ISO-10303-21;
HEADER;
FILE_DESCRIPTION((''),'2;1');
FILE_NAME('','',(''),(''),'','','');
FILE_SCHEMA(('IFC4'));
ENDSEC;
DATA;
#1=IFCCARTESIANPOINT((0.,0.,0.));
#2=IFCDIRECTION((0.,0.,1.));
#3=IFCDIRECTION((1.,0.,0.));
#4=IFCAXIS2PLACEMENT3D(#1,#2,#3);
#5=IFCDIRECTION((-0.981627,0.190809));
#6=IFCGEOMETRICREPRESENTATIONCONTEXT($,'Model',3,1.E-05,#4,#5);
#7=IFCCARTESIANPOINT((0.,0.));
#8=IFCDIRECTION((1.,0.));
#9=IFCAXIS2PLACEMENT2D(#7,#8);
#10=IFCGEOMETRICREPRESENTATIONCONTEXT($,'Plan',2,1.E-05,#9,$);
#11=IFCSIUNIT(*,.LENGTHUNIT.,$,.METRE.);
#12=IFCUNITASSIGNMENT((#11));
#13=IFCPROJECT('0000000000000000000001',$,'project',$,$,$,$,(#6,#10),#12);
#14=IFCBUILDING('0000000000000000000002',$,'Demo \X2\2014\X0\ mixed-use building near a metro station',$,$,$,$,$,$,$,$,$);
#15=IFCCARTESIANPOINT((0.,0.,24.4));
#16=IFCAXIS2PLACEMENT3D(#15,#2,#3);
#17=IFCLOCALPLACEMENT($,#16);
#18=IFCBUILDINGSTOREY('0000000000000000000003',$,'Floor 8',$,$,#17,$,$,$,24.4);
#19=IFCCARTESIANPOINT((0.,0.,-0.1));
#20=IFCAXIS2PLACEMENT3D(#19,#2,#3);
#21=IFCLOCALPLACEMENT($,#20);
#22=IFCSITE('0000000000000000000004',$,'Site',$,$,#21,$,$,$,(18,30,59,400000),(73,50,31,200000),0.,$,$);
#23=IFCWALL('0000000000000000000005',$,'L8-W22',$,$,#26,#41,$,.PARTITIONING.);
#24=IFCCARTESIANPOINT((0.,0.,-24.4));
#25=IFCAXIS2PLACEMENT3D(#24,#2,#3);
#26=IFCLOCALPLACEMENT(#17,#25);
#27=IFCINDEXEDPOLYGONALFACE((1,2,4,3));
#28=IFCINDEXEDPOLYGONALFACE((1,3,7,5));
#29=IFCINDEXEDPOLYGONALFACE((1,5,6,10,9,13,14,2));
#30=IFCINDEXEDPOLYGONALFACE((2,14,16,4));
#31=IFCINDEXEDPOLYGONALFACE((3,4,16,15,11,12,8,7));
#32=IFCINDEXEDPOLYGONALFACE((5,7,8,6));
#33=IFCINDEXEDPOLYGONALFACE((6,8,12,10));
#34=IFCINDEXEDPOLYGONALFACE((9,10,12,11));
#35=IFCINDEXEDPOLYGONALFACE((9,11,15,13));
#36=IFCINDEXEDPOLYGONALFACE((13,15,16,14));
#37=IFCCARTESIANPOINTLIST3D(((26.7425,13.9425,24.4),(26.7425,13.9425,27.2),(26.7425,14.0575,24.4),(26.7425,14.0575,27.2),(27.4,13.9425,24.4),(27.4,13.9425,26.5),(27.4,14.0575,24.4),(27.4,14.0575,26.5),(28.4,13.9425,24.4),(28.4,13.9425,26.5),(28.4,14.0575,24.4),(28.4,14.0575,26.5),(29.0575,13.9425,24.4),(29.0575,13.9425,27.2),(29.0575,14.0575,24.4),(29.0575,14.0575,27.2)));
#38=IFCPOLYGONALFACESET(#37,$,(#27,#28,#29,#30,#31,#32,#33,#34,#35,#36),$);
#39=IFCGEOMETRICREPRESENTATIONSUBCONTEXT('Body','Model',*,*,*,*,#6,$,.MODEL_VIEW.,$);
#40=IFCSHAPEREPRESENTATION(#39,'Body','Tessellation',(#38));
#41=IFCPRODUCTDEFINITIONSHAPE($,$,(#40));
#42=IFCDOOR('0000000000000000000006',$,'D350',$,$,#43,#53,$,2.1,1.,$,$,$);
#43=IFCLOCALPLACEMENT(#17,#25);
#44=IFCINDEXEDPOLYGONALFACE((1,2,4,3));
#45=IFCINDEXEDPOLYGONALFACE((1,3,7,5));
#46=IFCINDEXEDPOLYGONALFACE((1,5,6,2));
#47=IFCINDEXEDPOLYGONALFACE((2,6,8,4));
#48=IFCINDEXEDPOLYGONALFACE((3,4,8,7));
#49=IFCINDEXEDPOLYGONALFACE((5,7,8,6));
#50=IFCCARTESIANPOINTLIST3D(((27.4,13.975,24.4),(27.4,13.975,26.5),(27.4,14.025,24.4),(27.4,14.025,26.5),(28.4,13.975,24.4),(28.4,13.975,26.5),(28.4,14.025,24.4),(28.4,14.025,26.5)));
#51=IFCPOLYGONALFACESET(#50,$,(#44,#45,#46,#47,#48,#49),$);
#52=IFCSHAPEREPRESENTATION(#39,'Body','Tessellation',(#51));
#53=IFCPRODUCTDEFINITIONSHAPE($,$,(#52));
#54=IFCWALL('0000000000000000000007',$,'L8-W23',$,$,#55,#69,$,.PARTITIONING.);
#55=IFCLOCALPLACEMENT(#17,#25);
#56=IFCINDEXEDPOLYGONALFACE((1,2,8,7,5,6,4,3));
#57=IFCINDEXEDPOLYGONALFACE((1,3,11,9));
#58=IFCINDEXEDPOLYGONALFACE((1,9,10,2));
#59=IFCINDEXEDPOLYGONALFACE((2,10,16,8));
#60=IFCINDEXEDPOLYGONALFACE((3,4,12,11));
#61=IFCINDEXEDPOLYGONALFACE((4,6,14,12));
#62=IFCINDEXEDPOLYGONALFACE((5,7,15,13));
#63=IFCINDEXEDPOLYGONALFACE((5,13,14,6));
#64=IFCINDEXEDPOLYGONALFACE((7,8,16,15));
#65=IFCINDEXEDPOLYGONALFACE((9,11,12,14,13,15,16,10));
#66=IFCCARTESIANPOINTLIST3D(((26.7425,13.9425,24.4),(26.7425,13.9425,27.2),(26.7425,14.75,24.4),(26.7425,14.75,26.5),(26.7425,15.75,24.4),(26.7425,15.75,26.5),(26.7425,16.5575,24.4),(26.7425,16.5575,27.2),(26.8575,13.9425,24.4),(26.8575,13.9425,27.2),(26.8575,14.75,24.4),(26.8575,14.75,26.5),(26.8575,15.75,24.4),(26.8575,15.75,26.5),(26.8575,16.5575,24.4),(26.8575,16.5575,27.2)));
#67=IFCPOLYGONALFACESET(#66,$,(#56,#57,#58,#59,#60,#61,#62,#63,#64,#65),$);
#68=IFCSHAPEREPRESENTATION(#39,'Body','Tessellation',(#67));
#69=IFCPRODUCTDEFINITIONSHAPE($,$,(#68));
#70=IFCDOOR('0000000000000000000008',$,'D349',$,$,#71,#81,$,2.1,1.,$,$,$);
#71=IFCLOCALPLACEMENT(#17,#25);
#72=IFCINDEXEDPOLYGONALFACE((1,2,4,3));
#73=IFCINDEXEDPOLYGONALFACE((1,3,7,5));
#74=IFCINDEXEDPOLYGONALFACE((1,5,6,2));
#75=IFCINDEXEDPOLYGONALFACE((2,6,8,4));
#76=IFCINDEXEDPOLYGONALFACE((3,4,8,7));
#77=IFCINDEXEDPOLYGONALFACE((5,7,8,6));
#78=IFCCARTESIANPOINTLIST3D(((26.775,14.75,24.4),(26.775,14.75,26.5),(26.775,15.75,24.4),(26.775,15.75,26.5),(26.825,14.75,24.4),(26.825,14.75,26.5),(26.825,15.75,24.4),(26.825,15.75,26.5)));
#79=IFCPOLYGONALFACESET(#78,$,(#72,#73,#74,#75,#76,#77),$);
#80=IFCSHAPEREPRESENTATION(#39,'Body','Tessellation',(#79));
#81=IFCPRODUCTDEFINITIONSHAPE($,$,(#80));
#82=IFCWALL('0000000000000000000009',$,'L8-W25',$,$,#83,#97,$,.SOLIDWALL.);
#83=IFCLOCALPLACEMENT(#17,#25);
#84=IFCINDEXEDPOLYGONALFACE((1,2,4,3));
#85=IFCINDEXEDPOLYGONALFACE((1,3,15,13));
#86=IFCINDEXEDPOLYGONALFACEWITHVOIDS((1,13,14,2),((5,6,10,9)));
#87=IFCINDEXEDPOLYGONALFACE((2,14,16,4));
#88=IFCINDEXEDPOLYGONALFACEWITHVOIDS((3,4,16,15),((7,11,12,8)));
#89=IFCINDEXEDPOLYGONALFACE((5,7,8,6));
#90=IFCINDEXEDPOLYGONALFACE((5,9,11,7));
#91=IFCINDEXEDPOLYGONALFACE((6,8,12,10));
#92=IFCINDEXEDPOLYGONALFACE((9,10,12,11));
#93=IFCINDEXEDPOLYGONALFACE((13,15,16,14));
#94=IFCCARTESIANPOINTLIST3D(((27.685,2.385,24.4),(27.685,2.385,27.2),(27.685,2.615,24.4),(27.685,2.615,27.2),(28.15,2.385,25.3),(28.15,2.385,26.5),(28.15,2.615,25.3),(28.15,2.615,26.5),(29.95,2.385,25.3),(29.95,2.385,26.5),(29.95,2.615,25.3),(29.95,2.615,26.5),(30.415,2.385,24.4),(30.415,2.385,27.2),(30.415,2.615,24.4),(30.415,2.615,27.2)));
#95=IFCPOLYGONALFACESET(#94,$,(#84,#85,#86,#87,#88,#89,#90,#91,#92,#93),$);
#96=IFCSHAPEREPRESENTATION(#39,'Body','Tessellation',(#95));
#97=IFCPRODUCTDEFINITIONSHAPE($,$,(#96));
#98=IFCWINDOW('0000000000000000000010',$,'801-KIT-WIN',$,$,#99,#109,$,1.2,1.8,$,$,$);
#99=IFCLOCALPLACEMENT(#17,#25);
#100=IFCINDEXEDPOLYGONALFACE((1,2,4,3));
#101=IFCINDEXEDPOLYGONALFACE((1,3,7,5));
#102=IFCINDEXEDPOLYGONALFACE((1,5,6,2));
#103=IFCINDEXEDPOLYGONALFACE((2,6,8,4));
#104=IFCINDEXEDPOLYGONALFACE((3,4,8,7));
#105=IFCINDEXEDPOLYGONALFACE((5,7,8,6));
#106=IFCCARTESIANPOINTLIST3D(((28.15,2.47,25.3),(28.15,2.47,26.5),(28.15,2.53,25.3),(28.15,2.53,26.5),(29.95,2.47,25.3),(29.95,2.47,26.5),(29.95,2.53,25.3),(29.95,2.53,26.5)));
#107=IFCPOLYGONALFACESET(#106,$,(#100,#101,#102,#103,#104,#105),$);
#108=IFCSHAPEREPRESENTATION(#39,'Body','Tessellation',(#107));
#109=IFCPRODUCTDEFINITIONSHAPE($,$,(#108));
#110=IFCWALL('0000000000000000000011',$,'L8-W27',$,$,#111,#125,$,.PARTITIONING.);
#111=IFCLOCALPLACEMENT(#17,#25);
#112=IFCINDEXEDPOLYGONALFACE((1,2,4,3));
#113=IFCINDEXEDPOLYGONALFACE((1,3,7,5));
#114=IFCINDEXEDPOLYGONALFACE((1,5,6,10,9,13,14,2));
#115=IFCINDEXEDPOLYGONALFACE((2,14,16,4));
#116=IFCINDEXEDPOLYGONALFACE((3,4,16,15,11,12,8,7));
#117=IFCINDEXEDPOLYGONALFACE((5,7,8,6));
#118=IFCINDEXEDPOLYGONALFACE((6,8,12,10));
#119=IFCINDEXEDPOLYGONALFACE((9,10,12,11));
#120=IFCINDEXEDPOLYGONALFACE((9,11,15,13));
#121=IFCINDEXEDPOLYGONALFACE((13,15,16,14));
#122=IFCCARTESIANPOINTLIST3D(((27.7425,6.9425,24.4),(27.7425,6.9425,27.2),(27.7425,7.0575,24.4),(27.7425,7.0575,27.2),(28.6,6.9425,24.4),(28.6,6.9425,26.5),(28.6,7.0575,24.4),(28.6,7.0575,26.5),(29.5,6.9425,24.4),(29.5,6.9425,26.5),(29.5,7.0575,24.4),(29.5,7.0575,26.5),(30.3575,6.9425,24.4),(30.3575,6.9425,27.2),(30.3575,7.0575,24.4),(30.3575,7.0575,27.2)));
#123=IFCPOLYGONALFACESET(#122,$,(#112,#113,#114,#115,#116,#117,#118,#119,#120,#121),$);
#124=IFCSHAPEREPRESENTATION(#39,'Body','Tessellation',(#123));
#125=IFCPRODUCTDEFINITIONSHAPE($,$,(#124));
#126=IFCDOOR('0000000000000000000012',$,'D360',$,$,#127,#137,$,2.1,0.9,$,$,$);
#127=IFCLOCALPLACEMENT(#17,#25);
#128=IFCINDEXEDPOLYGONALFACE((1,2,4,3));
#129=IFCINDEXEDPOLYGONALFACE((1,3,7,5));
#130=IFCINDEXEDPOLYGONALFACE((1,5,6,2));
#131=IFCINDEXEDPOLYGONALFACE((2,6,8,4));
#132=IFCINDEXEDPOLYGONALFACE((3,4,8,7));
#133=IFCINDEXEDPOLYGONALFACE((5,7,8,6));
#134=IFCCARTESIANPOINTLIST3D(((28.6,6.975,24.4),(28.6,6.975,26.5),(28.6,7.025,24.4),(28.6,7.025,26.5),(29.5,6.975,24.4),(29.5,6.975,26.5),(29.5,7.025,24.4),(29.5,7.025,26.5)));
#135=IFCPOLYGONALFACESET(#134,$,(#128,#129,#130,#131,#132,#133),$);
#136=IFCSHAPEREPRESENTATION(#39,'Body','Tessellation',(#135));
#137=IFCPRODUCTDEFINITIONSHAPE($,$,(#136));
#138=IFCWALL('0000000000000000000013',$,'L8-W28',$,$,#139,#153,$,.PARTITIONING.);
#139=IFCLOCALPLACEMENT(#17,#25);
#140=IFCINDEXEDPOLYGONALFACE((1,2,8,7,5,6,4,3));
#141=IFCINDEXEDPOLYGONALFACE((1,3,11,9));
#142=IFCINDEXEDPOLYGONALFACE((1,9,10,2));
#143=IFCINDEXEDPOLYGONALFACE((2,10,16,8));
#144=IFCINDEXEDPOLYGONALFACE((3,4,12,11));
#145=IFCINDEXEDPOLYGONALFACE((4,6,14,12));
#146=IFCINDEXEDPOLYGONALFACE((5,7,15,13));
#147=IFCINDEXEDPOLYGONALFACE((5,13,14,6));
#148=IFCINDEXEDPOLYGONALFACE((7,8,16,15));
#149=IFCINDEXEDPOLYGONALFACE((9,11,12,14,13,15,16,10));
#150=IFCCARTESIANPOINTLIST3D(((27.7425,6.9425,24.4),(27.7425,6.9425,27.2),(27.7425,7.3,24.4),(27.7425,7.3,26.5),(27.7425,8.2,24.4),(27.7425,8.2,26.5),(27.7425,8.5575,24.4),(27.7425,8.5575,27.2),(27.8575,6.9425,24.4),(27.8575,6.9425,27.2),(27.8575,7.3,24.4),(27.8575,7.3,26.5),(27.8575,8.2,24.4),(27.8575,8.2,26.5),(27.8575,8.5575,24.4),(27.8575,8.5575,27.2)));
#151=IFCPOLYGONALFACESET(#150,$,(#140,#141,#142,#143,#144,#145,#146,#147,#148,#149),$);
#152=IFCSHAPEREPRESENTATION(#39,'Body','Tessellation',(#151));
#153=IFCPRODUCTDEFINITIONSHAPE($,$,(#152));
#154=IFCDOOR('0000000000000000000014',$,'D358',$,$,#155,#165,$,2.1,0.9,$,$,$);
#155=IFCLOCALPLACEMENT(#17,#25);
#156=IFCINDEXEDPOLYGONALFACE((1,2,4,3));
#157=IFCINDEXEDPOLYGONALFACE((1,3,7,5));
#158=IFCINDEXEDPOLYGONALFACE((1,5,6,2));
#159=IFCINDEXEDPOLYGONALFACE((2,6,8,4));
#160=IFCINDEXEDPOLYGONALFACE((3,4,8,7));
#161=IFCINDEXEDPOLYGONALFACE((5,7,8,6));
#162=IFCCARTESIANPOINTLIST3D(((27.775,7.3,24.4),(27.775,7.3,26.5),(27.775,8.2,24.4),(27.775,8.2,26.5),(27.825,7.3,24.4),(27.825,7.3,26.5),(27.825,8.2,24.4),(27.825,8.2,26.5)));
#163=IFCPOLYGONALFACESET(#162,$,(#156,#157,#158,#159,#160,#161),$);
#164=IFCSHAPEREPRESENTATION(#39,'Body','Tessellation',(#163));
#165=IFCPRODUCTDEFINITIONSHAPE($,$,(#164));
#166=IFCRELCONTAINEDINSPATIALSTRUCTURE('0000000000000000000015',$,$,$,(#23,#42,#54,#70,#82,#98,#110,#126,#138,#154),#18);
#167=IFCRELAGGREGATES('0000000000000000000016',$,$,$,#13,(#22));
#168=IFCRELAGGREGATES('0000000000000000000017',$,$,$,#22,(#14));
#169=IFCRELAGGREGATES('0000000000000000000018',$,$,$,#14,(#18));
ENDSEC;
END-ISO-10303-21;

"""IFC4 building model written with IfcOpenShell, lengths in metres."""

from ifc_helpers import new_model, si_unit, direction, frame, origin_with_axes, origin_2d_with_axis, place, context, subcontext, project, spatial, line, indexed_curve, outline, extrude, element, fill, save


model = new_model("IFC4")

# Units and contexts
model_context = context("Model", 3, precision=1e-05, world=origin_with_axes(), true_north=direction((-0.981627, 0.190809)))
plan_context = context("Plan", 2, precision=1e-05, world=origin_2d_with_axis())
body_context = subcontext(model_context, "Body", "Model", "MODEL_VIEW")
ifc_project = project(units=[si_unit("LENGTHUNIT", "METRE")], contexts=[model_context, plan_context])

# Site, building, storey
site_placement = place(None, frame((0.0, 0.0, -0.1), z_axis=(0.0, 0.0, 1.0), x_axis=(1.0, 0.0, 0.0)))
site = spatial("IfcSite", under=ifc_project, at=site_placement, Name="Site", RefLatitude=(18, 30, 59, 400000), RefLongitude=(73, 50, 31, 200000), RefElevation=0.0)
building = spatial("IfcBuilding", under=site, Name="Demo — mixed-use building near a metro station")
storey_placement = place(None, frame((0.0, 0.0, 24.4), z_axis=(0.0, 0.0, 1.0), x_axis=(1.0, 0.0, 0.0)))
storey = spatial("IfcBuildingStorey", under=building, at=storey_placement, Name="Floor 8", Elevation=24.4)

# Walls, openings, doors
wall_1_placement = place(storey_placement, frame((0.0, 0.0, -24.4), z_axis=(0.0, 0.0, 1.0), x_axis=(1.0, 0.0, 0.0)))
wall_1 = element("IfcWall", 1, at=wall_1_placement, inside=storey, Name="L8-W22", PredefinedType="PARTITIONING", context=body_context, shape_type="SweptSolid", body=[
    extrude(outline(indexed_curve([(29.0575, 13.9425), (26.7425, 13.9425), (26.7425, 14.0575), (29.0575, 14.0575)], segments=[line(1, 2, 3, 4, 1)])), frame((0.0, 0.0, 24.4), z_axis=(0.0, 0.0, 1.0), x_axis=(1.0, 0.0, 0.0)), (0.0, 0.0, 1.0), 2.8),
])
opening_1_placement = place(wall_1_placement, origin_with_axes())
opening_1 = element("IfcOpeningElement", 2, at=opening_1_placement, cuts=wall_1, context=body_context, shape_type="SweptSolid", body=[
    extrude(outline(indexed_curve([(28.4, 13.8925), (27.4, 13.8925), (27.4, 14.1075), (28.4, 14.1075)], segments=[line(1, 2, 3, 4, 1)])), frame((0.0, 0.0, 24.4), z_axis=(0.0, 0.0, 1.0), x_axis=(1.0, 0.0, 0.0)), (0.0, 0.0, 1.0), 2.1),
])
door_1_placement = place(storey_placement, frame((0.0, 0.0, -24.4), z_axis=(0.0, 0.0, 1.0), x_axis=(1.0, 0.0, 0.0)))
door_1 = element("IfcDoor", 3, at=door_1_placement, inside=storey, Name="D350", OverallHeight=2.1, OverallWidth=1.0, context=body_context, shape_type="SweptSolid", body=[
    extrude(outline(indexed_curve([(28.4, 13.975), (27.4, 13.975), (27.4, 14.025), (28.4, 14.025)], segments=[line(1, 2, 3, 4, 1)])), frame((0.0, 0.0, 24.4), z_axis=(0.0, 0.0, 1.0), x_axis=(1.0, 0.0, 0.0)), (0.0, 0.0, 1.0), 2.1),
])
fill(opening_1, door_1)
wall_2_placement = place(storey_placement, frame((0.0, 0.0, -24.4), z_axis=(0.0, 0.0, 1.0), x_axis=(1.0, 0.0, 0.0)))
wall_2 = element("IfcWall", 4, at=wall_2_placement, inside=storey, Name="L8-W23", PredefinedType="PARTITIONING", context=body_context, shape_type="SweptSolid", body=[
    extrude(outline(indexed_curve([(26.7425, 13.9425), (26.7425, 16.5575), (26.8575, 16.5575), (26.8575, 13.9425)], segments=[line(1, 2, 3, 4, 1)])), frame((0.0, 0.0, 24.4), z_axis=(0.0, 0.0, 1.0), x_axis=(1.0, 0.0, 0.0)), (0.0, 0.0, 1.0), 2.8),
])
opening_2_placement = place(wall_2_placement, origin_with_axes())
opening_2 = element("IfcOpeningElement", 5, at=opening_2_placement, cuts=wall_2, context=body_context, shape_type="SweptSolid", body=[
    extrude(outline(indexed_curve([(26.6925, 14.75), (26.6925, 15.75), (26.9075, 15.75), (26.9075, 14.75)], segments=[line(1, 2, 3, 4, 1)])), frame((0.0, 0.0, 24.4), z_axis=(0.0, 0.0, 1.0), x_axis=(1.0, 0.0, 0.0)), (0.0, 0.0, 1.0), 2.1),
])
door_2_placement = place(storey_placement, frame((0.0, 0.0, -24.4), z_axis=(0.0, 0.0, 1.0), x_axis=(1.0, 0.0, 0.0)))
door_2 = element("IfcDoor", 6, at=door_2_placement, inside=storey, Name="D349", OverallHeight=2.1, OverallWidth=1.0, context=body_context, shape_type="SweptSolid", body=[
    extrude(outline(indexed_curve([(26.775, 14.75), (26.775, 15.75), (26.825, 15.75), (26.825, 14.75)], segments=[line(1, 2, 3, 4, 1)])), frame((0.0, 0.0, 24.4), z_axis=(0.0, 0.0, 1.0), x_axis=(1.0, 0.0, 0.0)), (0.0, 0.0, 1.0), 2.1),
])
fill(opening_2, door_2)

# Wall, opening, window
wall_3_placement = place(storey_placement, frame((0.0, 0.0, -24.4), z_axis=(0.0, 0.0, 1.0), x_axis=(1.0, 0.0, 0.0)))
wall_3 = element("IfcWall", 7, at=wall_3_placement, inside=storey, Name="L8-W25", PredefinedType="SOLIDWALL", context=body_context, shape_type="SweptSolid", body=[
    extrude(outline(indexed_curve([(27.685, 2.615), (30.415, 2.615), (30.415, 2.385), (27.685, 2.385)], segments=[line(1, 2, 3, 4, 1)])), frame((0.0, 0.0, 24.4), z_axis=(0.0, 0.0, 1.0), x_axis=(1.0, 0.0, 0.0)), (0.0, 0.0, 1.0), 2.8),
])
opening_3_placement = place(wall_3_placement, origin_with_axes())
opening_3 = element("IfcOpeningElement", 8, at=opening_3_placement, cuts=wall_3, context=body_context, shape_type="SweptSolid", body=[
    extrude(outline(indexed_curve([(28.15, 2.665), (29.95, 2.665), (29.95, 2.335), (28.15, 2.335)], segments=[line(1, 2, 3, 4, 1)])), frame((0.0, 0.0, 25.3), z_axis=(0.0, 0.0, 1.0), x_axis=(1.0, 0.0, 0.0)), (0.0, 0.0, 1.0), 1.2),
])
window_placement = place(storey_placement, frame((0.0, 0.0, -24.4), z_axis=(0.0, 0.0, 1.0), x_axis=(1.0, 0.0, 0.0)))
window = element("IfcWindow", 9, at=window_placement, inside=storey, Name="801-KIT-WIN", OverallHeight=1.2, OverallWidth=1.8, context=body_context, shape_type="SweptSolid", body=[
    extrude(outline(indexed_curve([(28.15, 2.53), (29.95, 2.53), (29.95, 2.47), (28.15, 2.47)], segments=[line(1, 2, 3, 4, 1)])), frame((0.0, 0.0, 25.3), z_axis=(0.0, 0.0, 1.0), x_axis=(1.0, 0.0, 0.0)), (0.0, 0.0, 1.0), 1.2),
])
fill(opening_3, window)

# Walls, openings, doors
wall_4_placement = place(storey_placement, frame((0.0, 0.0, -24.4), z_axis=(0.0, 0.0, 1.0), x_axis=(1.0, 0.0, 0.0)))
wall_4 = element("IfcWall", 10, at=wall_4_placement, inside=storey, Name="L8-W27", PredefinedType="PARTITIONING", context=body_context, shape_type="SweptSolid", body=[
    extrude(outline(indexed_curve([(30.3575, 6.9425), (27.7425, 6.9425), (27.7425, 7.0575), (30.3575, 7.0575)], segments=[line(1, 2, 3, 4, 1)])), frame((0.0, 0.0, 24.4), z_axis=(0.0, 0.0, 1.0), x_axis=(1.0, 0.0, 0.0)), (0.0, 0.0, 1.0), 2.8),
])
opening_4_placement = place(wall_4_placement, origin_with_axes())
opening_4 = element("IfcOpeningElement", 11, at=opening_4_placement, cuts=wall_4, context=body_context, shape_type="SweptSolid", body=[
    extrude(outline(indexed_curve([(29.5, 6.8925), (28.6, 6.8925), (28.6, 7.1075), (29.5, 7.1075)], segments=[line(1, 2, 3, 4, 1)])), frame((0.0, 0.0, 24.4), z_axis=(0.0, 0.0, 1.0), x_axis=(1.0, 0.0, 0.0)), (0.0, 0.0, 1.0), 2.1),
])
door_3_placement = place(storey_placement, frame((0.0, 0.0, -24.4), z_axis=(0.0, 0.0, 1.0), x_axis=(1.0, 0.0, 0.0)))
door_3 = element("IfcDoor", 12, at=door_3_placement, inside=storey, Name="D360", OverallHeight=2.1, OverallWidth=0.9, context=body_context, shape_type="SweptSolid", body=[
    extrude(outline(indexed_curve([(29.5, 6.975), (28.6, 6.975), (28.6, 7.025), (29.5, 7.025)], segments=[line(1, 2, 3, 4, 1)])), frame((0.0, 0.0, 24.4), z_axis=(0.0, 0.0, 1.0), x_axis=(1.0, 0.0, 0.0)), (0.0, 0.0, 1.0), 2.1),
])
fill(opening_4, door_3)
wall_5_placement = place(storey_placement, frame((0.0, 0.0, -24.4), z_axis=(0.0, 0.0, 1.0), x_axis=(1.0, 0.0, 0.0)))
wall_5 = element("IfcWall", 13, at=wall_5_placement, inside=storey, Name="L8-W28", PredefinedType="PARTITIONING", context=body_context, shape_type="SweptSolid", body=[
    extrude(outline(indexed_curve([(27.7425, 6.9425), (27.7425, 8.5575), (27.8575, 8.5575), (27.8575, 6.9425)], segments=[line(1, 2, 3, 4, 1)])), frame((0.0, 0.0, 24.4), z_axis=(0.0, 0.0, 1.0), x_axis=(1.0, 0.0, 0.0)), (0.0, 0.0, 1.0), 2.8),
])
opening_5_placement = place(wall_5_placement, origin_with_axes())
opening_5 = element("IfcOpeningElement", 14, at=opening_5_placement, cuts=wall_5, context=body_context, shape_type="SweptSolid", body=[
    extrude(outline(indexed_curve([(27.6925, 7.3), (27.6925, 8.2), (27.9075, 8.2), (27.9075, 7.3)], segments=[line(1, 2, 3, 4, 1)])), frame((0.0, 0.0, 24.4), z_axis=(0.0, 0.0, 1.0), x_axis=(1.0, 0.0, 0.0)), (0.0, 0.0, 1.0), 2.1),
])
door_4_placement = place(storey_placement, frame((0.0, 0.0, -24.4), z_axis=(0.0, 0.0, 1.0), x_axis=(1.0, 0.0, 0.0)))
door_4 = element("IfcDoor", 15, at=door_4_placement, inside=storey, Name="D358", OverallHeight=2.1, OverallWidth=0.9, context=body_context, shape_type="SweptSolid", body=[
    extrude(outline(indexed_curve([(27.775, 7.3), (27.775, 8.2), (27.825, 8.2), (27.825, 7.3)], segments=[line(1, 2, 3, 4, 1)])), frame((0.0, 0.0, 24.4), z_axis=(0.0, 0.0, 1.0), x_axis=(1.0, 0.0, 0.0)), (0.0, 0.0, 1.0), 2.1),
])
fill(opening_5, door_4)

save(model, "model.ifc")
